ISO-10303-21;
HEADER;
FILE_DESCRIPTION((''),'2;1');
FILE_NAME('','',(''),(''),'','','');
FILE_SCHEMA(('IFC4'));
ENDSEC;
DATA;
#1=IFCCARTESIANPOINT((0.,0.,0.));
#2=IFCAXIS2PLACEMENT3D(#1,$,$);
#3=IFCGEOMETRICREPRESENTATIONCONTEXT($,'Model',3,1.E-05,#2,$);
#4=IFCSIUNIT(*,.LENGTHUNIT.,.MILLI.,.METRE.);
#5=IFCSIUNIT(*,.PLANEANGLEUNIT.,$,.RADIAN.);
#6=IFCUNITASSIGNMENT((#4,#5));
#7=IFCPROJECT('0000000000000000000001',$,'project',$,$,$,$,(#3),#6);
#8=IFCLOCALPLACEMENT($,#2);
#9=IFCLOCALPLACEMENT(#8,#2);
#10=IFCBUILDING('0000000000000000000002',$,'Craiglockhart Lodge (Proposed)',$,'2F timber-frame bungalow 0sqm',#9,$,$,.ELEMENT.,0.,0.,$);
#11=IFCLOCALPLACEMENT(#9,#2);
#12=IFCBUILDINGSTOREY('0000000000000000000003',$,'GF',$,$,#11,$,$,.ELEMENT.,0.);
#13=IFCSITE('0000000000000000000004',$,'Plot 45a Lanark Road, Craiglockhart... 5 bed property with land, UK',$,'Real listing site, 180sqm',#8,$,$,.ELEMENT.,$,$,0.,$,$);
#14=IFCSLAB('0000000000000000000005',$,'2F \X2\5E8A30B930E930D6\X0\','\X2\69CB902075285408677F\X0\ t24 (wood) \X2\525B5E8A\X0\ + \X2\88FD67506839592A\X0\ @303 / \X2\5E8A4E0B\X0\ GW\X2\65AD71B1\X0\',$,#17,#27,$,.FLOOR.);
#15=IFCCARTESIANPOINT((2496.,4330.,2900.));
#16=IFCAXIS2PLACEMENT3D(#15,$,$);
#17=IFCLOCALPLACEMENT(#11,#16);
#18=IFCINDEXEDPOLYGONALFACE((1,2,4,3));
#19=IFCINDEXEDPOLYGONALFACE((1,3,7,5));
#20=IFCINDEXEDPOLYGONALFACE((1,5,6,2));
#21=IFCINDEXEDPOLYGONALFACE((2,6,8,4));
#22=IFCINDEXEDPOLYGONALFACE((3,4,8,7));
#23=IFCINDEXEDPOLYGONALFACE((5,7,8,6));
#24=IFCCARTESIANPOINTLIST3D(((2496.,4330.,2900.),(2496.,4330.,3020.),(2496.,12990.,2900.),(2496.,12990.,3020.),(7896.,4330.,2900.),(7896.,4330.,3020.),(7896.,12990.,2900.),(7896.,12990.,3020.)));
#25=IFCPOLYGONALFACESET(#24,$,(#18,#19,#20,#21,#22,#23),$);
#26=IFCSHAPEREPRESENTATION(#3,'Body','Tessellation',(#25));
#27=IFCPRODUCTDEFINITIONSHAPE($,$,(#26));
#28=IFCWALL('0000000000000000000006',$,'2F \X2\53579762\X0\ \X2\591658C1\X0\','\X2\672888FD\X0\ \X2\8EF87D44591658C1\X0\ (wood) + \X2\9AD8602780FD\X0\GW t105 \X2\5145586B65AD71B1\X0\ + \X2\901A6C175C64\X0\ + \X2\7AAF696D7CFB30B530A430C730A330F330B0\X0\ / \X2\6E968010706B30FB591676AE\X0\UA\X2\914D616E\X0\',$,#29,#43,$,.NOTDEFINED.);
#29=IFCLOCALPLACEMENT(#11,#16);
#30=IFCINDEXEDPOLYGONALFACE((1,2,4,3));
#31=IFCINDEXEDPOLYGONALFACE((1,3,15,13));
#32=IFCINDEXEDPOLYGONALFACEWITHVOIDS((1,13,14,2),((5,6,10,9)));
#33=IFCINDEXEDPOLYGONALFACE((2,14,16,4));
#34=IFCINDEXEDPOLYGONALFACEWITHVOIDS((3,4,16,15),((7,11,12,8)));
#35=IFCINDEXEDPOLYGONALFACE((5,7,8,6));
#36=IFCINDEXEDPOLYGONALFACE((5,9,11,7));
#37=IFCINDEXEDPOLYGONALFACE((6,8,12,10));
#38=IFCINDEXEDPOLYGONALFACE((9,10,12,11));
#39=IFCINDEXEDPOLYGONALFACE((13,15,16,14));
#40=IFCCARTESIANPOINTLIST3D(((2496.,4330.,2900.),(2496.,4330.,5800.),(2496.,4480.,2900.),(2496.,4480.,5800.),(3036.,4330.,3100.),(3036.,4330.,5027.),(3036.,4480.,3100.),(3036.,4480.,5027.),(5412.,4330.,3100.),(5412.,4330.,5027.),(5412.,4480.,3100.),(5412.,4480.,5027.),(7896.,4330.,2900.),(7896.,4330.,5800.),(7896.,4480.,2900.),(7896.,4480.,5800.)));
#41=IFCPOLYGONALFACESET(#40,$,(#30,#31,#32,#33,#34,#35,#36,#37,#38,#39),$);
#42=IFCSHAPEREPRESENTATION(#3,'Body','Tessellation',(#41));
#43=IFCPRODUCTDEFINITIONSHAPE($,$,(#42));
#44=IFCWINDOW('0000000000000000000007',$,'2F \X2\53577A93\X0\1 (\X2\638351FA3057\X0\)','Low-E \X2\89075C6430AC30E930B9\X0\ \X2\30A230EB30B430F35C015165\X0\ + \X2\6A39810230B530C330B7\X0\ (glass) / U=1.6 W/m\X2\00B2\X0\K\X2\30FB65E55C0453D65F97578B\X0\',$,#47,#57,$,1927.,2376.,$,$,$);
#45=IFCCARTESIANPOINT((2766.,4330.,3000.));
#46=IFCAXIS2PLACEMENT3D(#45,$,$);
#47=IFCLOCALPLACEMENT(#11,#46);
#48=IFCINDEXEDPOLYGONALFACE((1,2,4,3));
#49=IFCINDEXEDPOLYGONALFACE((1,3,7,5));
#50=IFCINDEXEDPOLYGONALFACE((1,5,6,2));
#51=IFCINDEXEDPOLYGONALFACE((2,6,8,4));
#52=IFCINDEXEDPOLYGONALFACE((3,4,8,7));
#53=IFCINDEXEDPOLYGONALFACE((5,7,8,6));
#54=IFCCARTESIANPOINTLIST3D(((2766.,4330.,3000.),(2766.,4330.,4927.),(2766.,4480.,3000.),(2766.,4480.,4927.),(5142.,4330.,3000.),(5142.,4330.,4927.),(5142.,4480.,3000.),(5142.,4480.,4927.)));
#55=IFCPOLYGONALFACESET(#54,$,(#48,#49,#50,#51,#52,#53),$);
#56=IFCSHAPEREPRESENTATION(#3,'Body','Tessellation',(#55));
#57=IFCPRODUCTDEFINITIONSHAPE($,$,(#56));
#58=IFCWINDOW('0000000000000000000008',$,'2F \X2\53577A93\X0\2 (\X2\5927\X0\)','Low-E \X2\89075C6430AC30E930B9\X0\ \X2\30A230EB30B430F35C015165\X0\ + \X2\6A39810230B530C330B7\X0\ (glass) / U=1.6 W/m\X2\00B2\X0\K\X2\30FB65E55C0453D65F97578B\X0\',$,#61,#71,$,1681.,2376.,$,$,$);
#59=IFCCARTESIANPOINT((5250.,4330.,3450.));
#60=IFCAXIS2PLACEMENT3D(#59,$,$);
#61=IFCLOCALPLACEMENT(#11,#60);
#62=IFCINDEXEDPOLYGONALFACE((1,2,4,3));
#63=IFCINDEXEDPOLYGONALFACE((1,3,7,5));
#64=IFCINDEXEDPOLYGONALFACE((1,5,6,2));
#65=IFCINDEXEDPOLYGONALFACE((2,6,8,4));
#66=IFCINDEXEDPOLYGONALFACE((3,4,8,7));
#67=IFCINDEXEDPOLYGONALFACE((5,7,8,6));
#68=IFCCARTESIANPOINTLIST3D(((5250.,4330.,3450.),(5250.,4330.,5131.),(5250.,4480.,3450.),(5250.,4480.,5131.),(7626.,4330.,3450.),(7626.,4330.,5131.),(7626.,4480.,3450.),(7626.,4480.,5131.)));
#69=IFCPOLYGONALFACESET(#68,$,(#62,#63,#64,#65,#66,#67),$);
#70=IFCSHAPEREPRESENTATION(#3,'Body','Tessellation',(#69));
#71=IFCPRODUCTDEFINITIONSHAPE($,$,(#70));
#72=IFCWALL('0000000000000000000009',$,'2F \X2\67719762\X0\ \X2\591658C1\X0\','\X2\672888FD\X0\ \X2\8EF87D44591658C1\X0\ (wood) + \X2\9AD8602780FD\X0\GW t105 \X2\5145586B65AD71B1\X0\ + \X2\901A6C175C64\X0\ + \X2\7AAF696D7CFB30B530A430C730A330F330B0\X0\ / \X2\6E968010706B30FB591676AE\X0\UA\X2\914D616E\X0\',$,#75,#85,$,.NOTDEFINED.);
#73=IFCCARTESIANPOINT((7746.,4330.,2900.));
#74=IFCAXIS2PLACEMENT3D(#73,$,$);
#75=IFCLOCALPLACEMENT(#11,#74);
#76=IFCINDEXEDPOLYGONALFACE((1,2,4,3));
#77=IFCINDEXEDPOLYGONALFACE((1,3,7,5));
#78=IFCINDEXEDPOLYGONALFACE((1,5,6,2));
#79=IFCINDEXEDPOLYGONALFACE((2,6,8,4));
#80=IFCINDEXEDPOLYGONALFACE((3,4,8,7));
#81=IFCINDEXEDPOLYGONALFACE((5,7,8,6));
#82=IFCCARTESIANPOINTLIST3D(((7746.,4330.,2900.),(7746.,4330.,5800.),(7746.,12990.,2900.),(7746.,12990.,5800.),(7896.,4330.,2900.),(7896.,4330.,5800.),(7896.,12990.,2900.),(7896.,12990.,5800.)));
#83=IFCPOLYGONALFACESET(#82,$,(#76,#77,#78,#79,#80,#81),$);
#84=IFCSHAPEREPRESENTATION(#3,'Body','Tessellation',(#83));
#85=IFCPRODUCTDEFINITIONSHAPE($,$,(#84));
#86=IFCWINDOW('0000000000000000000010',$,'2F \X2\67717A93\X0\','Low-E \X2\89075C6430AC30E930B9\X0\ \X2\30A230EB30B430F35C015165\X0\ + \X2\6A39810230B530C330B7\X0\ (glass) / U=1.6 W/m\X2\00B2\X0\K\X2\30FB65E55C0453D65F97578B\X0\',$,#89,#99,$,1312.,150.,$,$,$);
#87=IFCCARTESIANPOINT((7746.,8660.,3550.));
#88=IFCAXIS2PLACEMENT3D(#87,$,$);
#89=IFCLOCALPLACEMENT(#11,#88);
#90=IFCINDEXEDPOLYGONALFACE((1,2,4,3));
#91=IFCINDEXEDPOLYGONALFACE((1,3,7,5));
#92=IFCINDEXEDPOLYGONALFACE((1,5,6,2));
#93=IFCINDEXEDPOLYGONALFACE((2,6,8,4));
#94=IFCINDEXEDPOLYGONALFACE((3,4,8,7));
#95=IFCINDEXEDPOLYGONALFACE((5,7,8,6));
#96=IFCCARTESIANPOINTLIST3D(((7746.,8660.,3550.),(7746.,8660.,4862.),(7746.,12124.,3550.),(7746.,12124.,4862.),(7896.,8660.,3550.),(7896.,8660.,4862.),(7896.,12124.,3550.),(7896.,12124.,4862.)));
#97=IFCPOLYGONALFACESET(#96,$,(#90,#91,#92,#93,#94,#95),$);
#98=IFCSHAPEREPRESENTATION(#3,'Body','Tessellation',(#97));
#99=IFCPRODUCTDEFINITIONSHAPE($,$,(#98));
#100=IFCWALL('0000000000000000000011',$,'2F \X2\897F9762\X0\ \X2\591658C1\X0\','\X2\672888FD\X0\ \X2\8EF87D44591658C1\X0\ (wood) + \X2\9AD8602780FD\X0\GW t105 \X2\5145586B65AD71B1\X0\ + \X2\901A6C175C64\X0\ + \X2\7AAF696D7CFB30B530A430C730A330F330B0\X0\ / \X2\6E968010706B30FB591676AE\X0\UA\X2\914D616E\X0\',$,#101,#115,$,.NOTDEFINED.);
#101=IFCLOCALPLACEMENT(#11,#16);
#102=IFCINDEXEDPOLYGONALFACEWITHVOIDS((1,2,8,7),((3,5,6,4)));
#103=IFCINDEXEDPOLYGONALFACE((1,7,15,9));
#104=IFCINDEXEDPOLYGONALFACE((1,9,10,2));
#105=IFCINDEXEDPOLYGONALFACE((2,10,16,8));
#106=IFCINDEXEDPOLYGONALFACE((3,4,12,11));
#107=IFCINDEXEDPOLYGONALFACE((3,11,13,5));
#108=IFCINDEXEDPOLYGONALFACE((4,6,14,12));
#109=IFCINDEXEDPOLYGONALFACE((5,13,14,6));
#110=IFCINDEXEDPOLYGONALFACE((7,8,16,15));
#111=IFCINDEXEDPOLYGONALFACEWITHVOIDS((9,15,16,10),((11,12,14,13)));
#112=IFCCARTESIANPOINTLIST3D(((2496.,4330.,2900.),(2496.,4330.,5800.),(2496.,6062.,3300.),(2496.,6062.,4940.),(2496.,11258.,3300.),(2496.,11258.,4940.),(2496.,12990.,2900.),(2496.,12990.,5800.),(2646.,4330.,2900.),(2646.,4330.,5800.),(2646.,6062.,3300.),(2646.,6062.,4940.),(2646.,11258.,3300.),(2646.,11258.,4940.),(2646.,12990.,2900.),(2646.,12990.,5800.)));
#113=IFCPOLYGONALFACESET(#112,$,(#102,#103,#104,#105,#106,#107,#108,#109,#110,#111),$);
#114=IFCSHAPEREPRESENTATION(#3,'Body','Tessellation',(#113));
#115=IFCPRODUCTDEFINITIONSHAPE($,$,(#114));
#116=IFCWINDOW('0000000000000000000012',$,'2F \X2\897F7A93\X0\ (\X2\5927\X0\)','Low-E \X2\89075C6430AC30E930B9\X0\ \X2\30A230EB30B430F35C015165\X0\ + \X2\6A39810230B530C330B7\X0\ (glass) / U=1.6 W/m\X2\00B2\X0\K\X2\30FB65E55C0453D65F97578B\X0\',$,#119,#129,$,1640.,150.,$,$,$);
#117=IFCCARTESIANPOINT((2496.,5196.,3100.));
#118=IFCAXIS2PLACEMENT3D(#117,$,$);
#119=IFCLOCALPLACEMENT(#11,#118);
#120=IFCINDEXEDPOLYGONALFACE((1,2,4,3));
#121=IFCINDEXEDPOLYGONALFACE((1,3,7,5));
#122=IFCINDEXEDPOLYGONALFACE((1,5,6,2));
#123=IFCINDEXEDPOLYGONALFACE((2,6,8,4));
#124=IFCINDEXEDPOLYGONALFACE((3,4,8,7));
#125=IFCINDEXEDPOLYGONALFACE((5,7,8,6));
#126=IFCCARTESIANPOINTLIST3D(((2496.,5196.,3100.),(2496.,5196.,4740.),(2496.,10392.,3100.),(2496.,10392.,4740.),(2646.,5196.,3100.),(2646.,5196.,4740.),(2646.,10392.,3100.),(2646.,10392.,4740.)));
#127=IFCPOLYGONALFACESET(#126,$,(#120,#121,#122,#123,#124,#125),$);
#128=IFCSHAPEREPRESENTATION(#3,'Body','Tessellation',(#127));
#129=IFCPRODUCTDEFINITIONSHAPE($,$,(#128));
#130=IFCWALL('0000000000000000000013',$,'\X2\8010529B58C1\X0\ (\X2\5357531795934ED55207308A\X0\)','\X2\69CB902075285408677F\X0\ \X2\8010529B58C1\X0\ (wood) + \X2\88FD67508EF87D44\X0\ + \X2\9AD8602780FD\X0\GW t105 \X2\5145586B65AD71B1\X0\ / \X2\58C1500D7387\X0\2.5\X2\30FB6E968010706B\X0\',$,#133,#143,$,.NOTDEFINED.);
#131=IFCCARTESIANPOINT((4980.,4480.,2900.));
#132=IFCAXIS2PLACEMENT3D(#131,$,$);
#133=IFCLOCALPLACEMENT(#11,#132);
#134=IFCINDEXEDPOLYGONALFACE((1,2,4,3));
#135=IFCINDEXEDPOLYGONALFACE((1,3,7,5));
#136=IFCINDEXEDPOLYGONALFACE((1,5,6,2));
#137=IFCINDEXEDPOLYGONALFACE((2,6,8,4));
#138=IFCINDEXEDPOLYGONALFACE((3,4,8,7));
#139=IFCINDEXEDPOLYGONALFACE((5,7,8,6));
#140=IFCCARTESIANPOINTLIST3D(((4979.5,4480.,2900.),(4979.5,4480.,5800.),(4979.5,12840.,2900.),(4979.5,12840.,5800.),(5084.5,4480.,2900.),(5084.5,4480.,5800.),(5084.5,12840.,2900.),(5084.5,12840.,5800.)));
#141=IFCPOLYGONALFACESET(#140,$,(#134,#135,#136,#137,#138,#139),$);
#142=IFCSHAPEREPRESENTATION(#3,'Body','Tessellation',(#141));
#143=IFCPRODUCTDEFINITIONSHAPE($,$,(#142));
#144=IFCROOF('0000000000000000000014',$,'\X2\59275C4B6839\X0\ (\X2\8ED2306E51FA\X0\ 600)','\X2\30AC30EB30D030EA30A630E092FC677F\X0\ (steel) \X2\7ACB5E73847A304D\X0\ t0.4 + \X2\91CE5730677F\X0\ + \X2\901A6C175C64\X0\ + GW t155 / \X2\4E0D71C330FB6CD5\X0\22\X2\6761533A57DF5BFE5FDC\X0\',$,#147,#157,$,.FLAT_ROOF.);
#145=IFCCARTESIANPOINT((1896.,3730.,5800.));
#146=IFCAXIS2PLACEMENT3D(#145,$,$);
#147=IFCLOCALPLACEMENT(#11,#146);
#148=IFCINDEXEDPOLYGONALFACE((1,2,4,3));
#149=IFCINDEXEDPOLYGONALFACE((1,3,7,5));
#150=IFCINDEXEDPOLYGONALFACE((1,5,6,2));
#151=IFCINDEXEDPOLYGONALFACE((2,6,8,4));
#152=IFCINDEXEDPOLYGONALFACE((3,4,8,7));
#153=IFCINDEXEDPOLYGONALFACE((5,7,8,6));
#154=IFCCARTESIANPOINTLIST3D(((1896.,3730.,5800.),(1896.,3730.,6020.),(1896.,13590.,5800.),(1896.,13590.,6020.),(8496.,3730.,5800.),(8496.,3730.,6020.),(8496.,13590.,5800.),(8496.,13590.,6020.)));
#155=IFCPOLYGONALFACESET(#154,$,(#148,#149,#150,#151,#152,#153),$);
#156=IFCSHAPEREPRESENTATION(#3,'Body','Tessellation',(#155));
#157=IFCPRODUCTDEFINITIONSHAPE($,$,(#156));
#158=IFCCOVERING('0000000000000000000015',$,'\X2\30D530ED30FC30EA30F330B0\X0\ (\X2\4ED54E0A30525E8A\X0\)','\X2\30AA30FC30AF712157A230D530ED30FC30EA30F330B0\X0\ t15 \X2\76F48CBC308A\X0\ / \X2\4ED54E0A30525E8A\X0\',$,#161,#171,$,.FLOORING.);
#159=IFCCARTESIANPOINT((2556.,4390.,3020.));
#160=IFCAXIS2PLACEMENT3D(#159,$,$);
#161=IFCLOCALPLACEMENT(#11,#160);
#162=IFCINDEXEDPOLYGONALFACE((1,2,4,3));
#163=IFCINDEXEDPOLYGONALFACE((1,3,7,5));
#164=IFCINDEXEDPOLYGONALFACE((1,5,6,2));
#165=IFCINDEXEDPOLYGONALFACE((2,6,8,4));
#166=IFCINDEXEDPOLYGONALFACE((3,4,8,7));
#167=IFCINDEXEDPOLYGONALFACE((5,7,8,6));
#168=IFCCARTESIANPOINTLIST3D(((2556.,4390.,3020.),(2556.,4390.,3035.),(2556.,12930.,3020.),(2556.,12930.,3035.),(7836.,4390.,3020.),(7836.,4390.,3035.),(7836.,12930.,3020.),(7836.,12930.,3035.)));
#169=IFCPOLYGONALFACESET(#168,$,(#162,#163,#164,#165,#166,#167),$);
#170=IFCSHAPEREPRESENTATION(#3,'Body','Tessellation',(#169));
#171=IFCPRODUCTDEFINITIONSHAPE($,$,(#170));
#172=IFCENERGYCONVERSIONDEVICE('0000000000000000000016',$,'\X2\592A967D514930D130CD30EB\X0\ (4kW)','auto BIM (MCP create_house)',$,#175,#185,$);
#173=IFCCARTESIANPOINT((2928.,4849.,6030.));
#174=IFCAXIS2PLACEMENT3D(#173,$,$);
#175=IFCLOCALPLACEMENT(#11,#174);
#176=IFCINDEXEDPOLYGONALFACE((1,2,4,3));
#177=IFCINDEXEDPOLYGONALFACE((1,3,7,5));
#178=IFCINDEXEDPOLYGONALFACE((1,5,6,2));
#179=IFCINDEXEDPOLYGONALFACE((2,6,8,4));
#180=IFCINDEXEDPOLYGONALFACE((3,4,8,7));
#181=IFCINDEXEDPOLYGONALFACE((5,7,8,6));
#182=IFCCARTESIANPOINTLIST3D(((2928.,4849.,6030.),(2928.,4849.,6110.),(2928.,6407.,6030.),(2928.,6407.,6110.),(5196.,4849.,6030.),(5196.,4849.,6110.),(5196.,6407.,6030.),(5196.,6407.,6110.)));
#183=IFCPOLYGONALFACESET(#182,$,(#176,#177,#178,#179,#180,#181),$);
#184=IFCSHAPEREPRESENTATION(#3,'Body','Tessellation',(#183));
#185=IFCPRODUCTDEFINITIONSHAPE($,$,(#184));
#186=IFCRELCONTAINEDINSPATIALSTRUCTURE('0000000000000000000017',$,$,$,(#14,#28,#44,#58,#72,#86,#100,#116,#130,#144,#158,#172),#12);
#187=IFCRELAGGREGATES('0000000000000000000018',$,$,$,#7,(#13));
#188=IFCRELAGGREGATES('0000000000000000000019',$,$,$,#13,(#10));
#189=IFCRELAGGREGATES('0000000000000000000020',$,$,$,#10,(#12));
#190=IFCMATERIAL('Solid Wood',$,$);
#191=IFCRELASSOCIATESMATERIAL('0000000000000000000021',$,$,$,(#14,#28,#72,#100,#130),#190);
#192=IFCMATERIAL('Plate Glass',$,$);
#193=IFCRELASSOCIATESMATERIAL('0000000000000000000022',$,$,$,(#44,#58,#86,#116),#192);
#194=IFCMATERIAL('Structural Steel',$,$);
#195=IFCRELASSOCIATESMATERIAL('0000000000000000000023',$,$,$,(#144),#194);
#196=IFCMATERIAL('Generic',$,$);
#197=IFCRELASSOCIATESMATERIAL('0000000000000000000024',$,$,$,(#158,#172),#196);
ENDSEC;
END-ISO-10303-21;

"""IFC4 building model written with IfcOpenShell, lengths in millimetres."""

from ifc_helpers import new_model, si_unit, frame, frame_2d, origin, place, context, project, spatial, rectangle, extrude, material, element, fill, save


model = new_model("IFC4")

# Units and contexts
model_context = context("Model", 3, precision=1e-05, world=origin())
ifc_project = project(units=[si_unit("LENGTHUNIT", "METRE", prefix="MILLI"), si_unit("PLANEANGLEUNIT", "RADIAN")], contexts=[model_context])

# Site, building, storey
site_placement = place(None, origin())
site = spatial("IfcSite", under=ifc_project, at=site_placement, Name="Plot 45a Lanark Road, Craiglockhart... 5 bed property with land, UK", ObjectType="Real listing site, 180sqm", CompositionType="ELEMENT", RefElevation=0.0)
building_placement = place(site_placement, origin())
building = spatial("IfcBuilding", under=site, at=building_placement, Name="Craiglockhart Lodge (Proposed)", ObjectType="2F timber-frame bungalow 0sqm", CompositionType="ELEMENT", ElevationOfRefHeight=0.0, ElevationOfTerrain=0.0)
storey_placement = place(building_placement, origin())
storey = spatial("IfcBuildingStorey", under=building, at=storey_placement, Name="GF", CompositionType="ELEMENT", Elevation=0.0)

# Slab
ifc_material_1 = material(Name="Solid Wood")
slab_placement = place(storey_placement, frame((2496.0, 4330.0, 2900.0)))
element("IfcSlab", 1, at=slab_placement, inside=storey, material=ifc_material_1, Name="2F 床スラブ", Description="構造用合板 t24 (wood) 剛床 + 製材根太 @303 / 床下 GW断熱", PredefinedType="FLOOR", context=model_context, shape_type="SweptSolid", body=[
    extrude(rectangle(XDim=5400.0, YDim=8660.0, at=frame_2d((2700.0, 4330.0))), frame((2496.0, 4330.0, 2900.0)), (0.0, 0.0, 1.0), 120.0),
])

# Wall, openings, windows
wall_1_placement = place(storey_placement, frame((2496.0, 4330.0, 2900.0)))
wall_1 = element("IfcWall", 2, at=wall_1_placement, inside=storey, material=ifc_material_1, Name="2F 南面 外壁", Description="木製 軸組外壁 (wood) + 高性能GW t105 充填断熱 + 通気層 + 窯業系サイディング / 準耐火・外皮UA配慮", PredefinedType="NOTDEFINED", context=model_context, shape_type="SweptSolid", body=[
    extrude(rectangle(XDim=5400.0, YDim=150.0, at=frame_2d((2700.0, 75.0))), frame((2496.0, 4330.0, 2900.0)), (0.0, 0.0, 1.0), 2900.0),
])
opening_1_placement = place(storey_placement, frame((2766.0, 4330.0, 3000.0)))
opening_1 = element("IfcOpeningElement", 3, at=opening_1_placement, cuts=wall_1, PredefinedType="NOTDEFINED", context=model_context, shape_type="SweptSolid", body=[
    extrude(rectangle(XDim=2376.0, YDim=150.0, at=frame_2d((1188.0, 75.0))), frame((2766.0, 4330.0, 3000.0)), (0.0, 0.0, 1.0), 1927.0),
])
opening_2_placement = place(storey_placement, frame((5250.0, 4330.0, 3450.0)))
opening_2 = element("IfcOpeningElement", 4, at=opening_2_placement, cuts=wall_1, PredefinedType="NOTDEFINED", context=model_context, shape_type="SweptSolid", body=[
    extrude(rectangle(XDim=2376.0, YDim=150.0, at=frame_2d((1188.0, 75.0))), frame((5250.0, 4330.0, 3450.0)), (0.0, 0.0, 1.0), 1681.0),
])
ifc_material_2 = material(Name="Plate Glass")
window_1_placement = place(storey_placement, frame((2766.0, 4330.0, 3000.0)))
window_1 = element("IfcWindow", 5, at=window_1_placement, inside=storey, material=ifc_material_2, Name="2F 南窓1 (掃出し)", Description="Low-E 複層ガラス アルゴン封入 + 樹脂サッシ (glass) / U=1.6 W/m²K・日射取得型", OverallHeight=1927.0, OverallWidth=2376.0, context=model_context, shape_type="SweptSolid", body=[
    extrude(rectangle(XDim=2376.0, YDim=150.0, at=frame_2d((1188.0, 75.0))), frame((2766.0, 4330.0, 3000.0)), (0.0, 0.0, 1.0), 1927.0),
])
fill(opening_1, window_1)
window_2_placement = place(storey_placement, frame((5250.0, 4330.0, 3450.0)))
window_2 = element("IfcWindow", 6, at=window_2_placement, inside=storey, material=ifc_material_2, Name="2F 南窓2 (大)", Description="Low-E 複層ガラス アルゴン封入 + 樹脂サッシ (glass) / U=1.6 W/m²K・日射取得型", OverallHeight=1681.0, OverallWidth=2376.0, context=model_context, shape_type="SweptSolid", body=[
    extrude(rectangle(XDim=2376.0, YDim=150.0, at=frame_2d((1188.0, 75.0))), frame((5250.0, 4330.0, 3450.0)), (0.0, 0.0, 1.0), 1681.0),
])
fill(opening_2, window_2)

# Walls, openings, windows
wall_2_placement = place(storey_placement, frame((7746.0, 4330.0, 2900.0)))
wall_2 = element("IfcWall", 7, at=wall_2_placement, inside=storey, material=ifc_material_1, Name="2F 東面 外壁", Description="木製 軸組外壁 (wood) + 高性能GW t105 充填断熱 + 通気層 + 窯業系サイディング / 準耐火・外皮UA配慮", PredefinedType="NOTDEFINED", context=model_context, shape_type="SweptSolid", body=[
    extrude(rectangle(XDim=150.0, YDim=8660.0, at=frame_2d((75.0, 4330.0))), frame((7746.0, 4330.0, 2900.0)), (0.0, 0.0, 1.0), 2900.0),
])
opening_3_placement = place(storey_placement, frame((7746.0, 8660.0, 3550.0)))
opening_3 = element("IfcOpeningElement", 8, at=opening_3_placement, cuts=wall_2, PredefinedType="NOTDEFINED", context=model_context, shape_type="SweptSolid", body=[
    extrude(rectangle(XDim=150.0, YDim=3464.0, at=frame_2d((75.0, 1732.0))), frame((7746.0, 8660.0, 3550.0)), (0.0, 0.0, 1.0), 1312.0),
])
window_3_placement = place(storey_placement, frame((7746.0, 8660.0, 3550.0)))
window_3 = element("IfcWindow", 9, at=window_3_placement, inside=storey, material=ifc_material_2, Name="2F 東窓", Description="Low-E 複層ガラス アルゴン封入 + 樹脂サッシ (glass) / U=1.6 W/m²K・日射取得型", OverallHeight=1312.0, OverallWidth=150.0, context=model_context, shape_type="SweptSolid", body=[
    extrude(rectangle(XDim=150.0, YDim=3464.0, at=frame_2d((75.0, 1732.0))), frame((7746.0, 8660.0, 3550.0)), (0.0, 0.0, 1.0), 1312.0),
])
fill(opening_3, window_3)
wall_3_placement = place(storey_placement, frame((2496.0, 4330.0, 2900.0)))
wall_3 = element("IfcWall", 10, at=wall_3_placement, inside=storey, material=ifc_material_1, Name="2F 西面 外壁", Description="木製 軸組外壁 (wood) + 高性能GW t105 充填断熱 + 通気層 + 窯業系サイディング / 準耐火・外皮UA配慮", PredefinedType="NOTDEFINED", context=model_context, shape_type="SweptSolid", body=[
    extrude(rectangle(XDim=150.0, YDim=8660.0, at=frame_2d((75.0, 4330.0))), frame((2496.0, 4330.0, 2900.0)), (0.0, 0.0, 1.0), 2900.0),
])
opening_4_placement = place(storey_placement, frame((2496.0, 5196.0, 3100.0)))
opening_4 = element("IfcOpeningElement", 11, at=opening_4_placement, cuts=wall_3, PredefinedType="NOTDEFINED", context=model_context, shape_type="SweptSolid", body=[
    extrude(rectangle(XDim=150.0, YDim=5196.0, at=frame_2d((75.0, 2598.0))), frame((2496.0, 5196.0, 3100.0)), (0.0, 0.0, 1.0), 1640.0),
])
window_4_placement = place(storey_placement, frame((2496.0, 5196.0, 3100.0)))
window_4 = element("IfcWindow", 12, at=window_4_placement, inside=storey, material=ifc_material_2, Name="2F 西窓 (大)", Description="Low-E 複層ガラス アルゴン封入 + 樹脂サッシ (glass) / U=1.6 W/m²K・日射取得型", OverallHeight=1640.0, OverallWidth=150.0, context=model_context, shape_type="SweptSolid", body=[
    extrude(rectangle(XDim=150.0, YDim=5196.0, at=frame_2d((75.0, 2598.0))), frame((2496.0, 5196.0, 3100.0)), (0.0, 0.0, 1.0), 1640.0),
])
fill(opening_4, window_4)

# Wall
wall_4_placement = place(storey_placement, frame((4980.0, 4480.0, 2900.0)))
element("IfcWall", 13, at=wall_4_placement, inside=storey, material=ifc_material_1, Name="耐力壁 (南北間仕切り)", Description="構造用合板 耐力壁 (wood) + 製材軸組 + 高性能GW t105 充填断熱 / 壁倍率2.5・準耐火", PredefinedType="NOTDEFINED", context=model_context, shape_type="SweptSolid", body=[
    extrude(rectangle(XDim=105.0, YDim=8360.0, at=frame_2d((52.0, 4180.0))), frame((4980.0, 4480.0, 2900.0)), (0.0, 0.0, 1.0), 2900.0),
])

# Roof
ifc_material_3 = material(Name="Structural Steel")
roof_placement = place(storey_placement, frame((1896.0, 3730.0, 5800.0)))
element("IfcRoof", 14, at=roof_placement, inside=storey, material=ifc_material_3, Name="大屋根 (軒の出 600)", Description="ガルバリウム鋼板 (steel) 立平葺き t0.4 + 野地板 + 通気層 + GW t155 / 不燃・法22条区域対応", PredefinedType="FLAT_ROOF", context=model_context, shape_type="SweptSolid", body=[
    extrude(rectangle(XDim=6600.0, YDim=9860.0, at=frame_2d((3300.0, 4930.0))), frame((1896.0, 3730.0, 5800.0)), (0.0, 0.0, 1.0), 220.0),
])

# Covering
ifc_material_4 = material(Name="Generic")
covering_placement = place(storey_placement, frame((2556.0, 4390.0, 3020.0)))
element("IfcCovering", 15, at=covering_placement, inside=storey, material=ifc_material_4, Name="フローリング (仕上げ床)", Description="オーク無垢フローリング t15 直貼り / 仕上げ床", PredefinedType="FLOORING", context=model_context, shape_type="SweptSolid", body=[
    extrude(rectangle(XDim=5280.0, YDim=8540.0, at=frame_2d((2640.0, 4270.0))), frame((2556.0, 4390.0, 3020.0)), (0.0, 0.0, 1.0), 15.0),
])

# Energy conversion device
energy_conversion_device_placement = place(storey_placement, frame((2928.0, 4849.0, 6030.0)))
element("IfcEnergyConversionDevice", 16, at=energy_conversion_device_placement, inside=storey, material=ifc_material_4, Name="太陽光パネル (4kW)", Description="auto BIM (MCP create_house)", context=model_context, shape_type="SweptSolid", body=[
    extrude(rectangle(XDim=2268.0, YDim=1558.0, at=frame_2d((1134.0, 779.0))), frame((2928.0, 4849.0, 6030.0)), (0.0, 0.0, 1.0), 80.0),
])

save(model, "model.ifc")
